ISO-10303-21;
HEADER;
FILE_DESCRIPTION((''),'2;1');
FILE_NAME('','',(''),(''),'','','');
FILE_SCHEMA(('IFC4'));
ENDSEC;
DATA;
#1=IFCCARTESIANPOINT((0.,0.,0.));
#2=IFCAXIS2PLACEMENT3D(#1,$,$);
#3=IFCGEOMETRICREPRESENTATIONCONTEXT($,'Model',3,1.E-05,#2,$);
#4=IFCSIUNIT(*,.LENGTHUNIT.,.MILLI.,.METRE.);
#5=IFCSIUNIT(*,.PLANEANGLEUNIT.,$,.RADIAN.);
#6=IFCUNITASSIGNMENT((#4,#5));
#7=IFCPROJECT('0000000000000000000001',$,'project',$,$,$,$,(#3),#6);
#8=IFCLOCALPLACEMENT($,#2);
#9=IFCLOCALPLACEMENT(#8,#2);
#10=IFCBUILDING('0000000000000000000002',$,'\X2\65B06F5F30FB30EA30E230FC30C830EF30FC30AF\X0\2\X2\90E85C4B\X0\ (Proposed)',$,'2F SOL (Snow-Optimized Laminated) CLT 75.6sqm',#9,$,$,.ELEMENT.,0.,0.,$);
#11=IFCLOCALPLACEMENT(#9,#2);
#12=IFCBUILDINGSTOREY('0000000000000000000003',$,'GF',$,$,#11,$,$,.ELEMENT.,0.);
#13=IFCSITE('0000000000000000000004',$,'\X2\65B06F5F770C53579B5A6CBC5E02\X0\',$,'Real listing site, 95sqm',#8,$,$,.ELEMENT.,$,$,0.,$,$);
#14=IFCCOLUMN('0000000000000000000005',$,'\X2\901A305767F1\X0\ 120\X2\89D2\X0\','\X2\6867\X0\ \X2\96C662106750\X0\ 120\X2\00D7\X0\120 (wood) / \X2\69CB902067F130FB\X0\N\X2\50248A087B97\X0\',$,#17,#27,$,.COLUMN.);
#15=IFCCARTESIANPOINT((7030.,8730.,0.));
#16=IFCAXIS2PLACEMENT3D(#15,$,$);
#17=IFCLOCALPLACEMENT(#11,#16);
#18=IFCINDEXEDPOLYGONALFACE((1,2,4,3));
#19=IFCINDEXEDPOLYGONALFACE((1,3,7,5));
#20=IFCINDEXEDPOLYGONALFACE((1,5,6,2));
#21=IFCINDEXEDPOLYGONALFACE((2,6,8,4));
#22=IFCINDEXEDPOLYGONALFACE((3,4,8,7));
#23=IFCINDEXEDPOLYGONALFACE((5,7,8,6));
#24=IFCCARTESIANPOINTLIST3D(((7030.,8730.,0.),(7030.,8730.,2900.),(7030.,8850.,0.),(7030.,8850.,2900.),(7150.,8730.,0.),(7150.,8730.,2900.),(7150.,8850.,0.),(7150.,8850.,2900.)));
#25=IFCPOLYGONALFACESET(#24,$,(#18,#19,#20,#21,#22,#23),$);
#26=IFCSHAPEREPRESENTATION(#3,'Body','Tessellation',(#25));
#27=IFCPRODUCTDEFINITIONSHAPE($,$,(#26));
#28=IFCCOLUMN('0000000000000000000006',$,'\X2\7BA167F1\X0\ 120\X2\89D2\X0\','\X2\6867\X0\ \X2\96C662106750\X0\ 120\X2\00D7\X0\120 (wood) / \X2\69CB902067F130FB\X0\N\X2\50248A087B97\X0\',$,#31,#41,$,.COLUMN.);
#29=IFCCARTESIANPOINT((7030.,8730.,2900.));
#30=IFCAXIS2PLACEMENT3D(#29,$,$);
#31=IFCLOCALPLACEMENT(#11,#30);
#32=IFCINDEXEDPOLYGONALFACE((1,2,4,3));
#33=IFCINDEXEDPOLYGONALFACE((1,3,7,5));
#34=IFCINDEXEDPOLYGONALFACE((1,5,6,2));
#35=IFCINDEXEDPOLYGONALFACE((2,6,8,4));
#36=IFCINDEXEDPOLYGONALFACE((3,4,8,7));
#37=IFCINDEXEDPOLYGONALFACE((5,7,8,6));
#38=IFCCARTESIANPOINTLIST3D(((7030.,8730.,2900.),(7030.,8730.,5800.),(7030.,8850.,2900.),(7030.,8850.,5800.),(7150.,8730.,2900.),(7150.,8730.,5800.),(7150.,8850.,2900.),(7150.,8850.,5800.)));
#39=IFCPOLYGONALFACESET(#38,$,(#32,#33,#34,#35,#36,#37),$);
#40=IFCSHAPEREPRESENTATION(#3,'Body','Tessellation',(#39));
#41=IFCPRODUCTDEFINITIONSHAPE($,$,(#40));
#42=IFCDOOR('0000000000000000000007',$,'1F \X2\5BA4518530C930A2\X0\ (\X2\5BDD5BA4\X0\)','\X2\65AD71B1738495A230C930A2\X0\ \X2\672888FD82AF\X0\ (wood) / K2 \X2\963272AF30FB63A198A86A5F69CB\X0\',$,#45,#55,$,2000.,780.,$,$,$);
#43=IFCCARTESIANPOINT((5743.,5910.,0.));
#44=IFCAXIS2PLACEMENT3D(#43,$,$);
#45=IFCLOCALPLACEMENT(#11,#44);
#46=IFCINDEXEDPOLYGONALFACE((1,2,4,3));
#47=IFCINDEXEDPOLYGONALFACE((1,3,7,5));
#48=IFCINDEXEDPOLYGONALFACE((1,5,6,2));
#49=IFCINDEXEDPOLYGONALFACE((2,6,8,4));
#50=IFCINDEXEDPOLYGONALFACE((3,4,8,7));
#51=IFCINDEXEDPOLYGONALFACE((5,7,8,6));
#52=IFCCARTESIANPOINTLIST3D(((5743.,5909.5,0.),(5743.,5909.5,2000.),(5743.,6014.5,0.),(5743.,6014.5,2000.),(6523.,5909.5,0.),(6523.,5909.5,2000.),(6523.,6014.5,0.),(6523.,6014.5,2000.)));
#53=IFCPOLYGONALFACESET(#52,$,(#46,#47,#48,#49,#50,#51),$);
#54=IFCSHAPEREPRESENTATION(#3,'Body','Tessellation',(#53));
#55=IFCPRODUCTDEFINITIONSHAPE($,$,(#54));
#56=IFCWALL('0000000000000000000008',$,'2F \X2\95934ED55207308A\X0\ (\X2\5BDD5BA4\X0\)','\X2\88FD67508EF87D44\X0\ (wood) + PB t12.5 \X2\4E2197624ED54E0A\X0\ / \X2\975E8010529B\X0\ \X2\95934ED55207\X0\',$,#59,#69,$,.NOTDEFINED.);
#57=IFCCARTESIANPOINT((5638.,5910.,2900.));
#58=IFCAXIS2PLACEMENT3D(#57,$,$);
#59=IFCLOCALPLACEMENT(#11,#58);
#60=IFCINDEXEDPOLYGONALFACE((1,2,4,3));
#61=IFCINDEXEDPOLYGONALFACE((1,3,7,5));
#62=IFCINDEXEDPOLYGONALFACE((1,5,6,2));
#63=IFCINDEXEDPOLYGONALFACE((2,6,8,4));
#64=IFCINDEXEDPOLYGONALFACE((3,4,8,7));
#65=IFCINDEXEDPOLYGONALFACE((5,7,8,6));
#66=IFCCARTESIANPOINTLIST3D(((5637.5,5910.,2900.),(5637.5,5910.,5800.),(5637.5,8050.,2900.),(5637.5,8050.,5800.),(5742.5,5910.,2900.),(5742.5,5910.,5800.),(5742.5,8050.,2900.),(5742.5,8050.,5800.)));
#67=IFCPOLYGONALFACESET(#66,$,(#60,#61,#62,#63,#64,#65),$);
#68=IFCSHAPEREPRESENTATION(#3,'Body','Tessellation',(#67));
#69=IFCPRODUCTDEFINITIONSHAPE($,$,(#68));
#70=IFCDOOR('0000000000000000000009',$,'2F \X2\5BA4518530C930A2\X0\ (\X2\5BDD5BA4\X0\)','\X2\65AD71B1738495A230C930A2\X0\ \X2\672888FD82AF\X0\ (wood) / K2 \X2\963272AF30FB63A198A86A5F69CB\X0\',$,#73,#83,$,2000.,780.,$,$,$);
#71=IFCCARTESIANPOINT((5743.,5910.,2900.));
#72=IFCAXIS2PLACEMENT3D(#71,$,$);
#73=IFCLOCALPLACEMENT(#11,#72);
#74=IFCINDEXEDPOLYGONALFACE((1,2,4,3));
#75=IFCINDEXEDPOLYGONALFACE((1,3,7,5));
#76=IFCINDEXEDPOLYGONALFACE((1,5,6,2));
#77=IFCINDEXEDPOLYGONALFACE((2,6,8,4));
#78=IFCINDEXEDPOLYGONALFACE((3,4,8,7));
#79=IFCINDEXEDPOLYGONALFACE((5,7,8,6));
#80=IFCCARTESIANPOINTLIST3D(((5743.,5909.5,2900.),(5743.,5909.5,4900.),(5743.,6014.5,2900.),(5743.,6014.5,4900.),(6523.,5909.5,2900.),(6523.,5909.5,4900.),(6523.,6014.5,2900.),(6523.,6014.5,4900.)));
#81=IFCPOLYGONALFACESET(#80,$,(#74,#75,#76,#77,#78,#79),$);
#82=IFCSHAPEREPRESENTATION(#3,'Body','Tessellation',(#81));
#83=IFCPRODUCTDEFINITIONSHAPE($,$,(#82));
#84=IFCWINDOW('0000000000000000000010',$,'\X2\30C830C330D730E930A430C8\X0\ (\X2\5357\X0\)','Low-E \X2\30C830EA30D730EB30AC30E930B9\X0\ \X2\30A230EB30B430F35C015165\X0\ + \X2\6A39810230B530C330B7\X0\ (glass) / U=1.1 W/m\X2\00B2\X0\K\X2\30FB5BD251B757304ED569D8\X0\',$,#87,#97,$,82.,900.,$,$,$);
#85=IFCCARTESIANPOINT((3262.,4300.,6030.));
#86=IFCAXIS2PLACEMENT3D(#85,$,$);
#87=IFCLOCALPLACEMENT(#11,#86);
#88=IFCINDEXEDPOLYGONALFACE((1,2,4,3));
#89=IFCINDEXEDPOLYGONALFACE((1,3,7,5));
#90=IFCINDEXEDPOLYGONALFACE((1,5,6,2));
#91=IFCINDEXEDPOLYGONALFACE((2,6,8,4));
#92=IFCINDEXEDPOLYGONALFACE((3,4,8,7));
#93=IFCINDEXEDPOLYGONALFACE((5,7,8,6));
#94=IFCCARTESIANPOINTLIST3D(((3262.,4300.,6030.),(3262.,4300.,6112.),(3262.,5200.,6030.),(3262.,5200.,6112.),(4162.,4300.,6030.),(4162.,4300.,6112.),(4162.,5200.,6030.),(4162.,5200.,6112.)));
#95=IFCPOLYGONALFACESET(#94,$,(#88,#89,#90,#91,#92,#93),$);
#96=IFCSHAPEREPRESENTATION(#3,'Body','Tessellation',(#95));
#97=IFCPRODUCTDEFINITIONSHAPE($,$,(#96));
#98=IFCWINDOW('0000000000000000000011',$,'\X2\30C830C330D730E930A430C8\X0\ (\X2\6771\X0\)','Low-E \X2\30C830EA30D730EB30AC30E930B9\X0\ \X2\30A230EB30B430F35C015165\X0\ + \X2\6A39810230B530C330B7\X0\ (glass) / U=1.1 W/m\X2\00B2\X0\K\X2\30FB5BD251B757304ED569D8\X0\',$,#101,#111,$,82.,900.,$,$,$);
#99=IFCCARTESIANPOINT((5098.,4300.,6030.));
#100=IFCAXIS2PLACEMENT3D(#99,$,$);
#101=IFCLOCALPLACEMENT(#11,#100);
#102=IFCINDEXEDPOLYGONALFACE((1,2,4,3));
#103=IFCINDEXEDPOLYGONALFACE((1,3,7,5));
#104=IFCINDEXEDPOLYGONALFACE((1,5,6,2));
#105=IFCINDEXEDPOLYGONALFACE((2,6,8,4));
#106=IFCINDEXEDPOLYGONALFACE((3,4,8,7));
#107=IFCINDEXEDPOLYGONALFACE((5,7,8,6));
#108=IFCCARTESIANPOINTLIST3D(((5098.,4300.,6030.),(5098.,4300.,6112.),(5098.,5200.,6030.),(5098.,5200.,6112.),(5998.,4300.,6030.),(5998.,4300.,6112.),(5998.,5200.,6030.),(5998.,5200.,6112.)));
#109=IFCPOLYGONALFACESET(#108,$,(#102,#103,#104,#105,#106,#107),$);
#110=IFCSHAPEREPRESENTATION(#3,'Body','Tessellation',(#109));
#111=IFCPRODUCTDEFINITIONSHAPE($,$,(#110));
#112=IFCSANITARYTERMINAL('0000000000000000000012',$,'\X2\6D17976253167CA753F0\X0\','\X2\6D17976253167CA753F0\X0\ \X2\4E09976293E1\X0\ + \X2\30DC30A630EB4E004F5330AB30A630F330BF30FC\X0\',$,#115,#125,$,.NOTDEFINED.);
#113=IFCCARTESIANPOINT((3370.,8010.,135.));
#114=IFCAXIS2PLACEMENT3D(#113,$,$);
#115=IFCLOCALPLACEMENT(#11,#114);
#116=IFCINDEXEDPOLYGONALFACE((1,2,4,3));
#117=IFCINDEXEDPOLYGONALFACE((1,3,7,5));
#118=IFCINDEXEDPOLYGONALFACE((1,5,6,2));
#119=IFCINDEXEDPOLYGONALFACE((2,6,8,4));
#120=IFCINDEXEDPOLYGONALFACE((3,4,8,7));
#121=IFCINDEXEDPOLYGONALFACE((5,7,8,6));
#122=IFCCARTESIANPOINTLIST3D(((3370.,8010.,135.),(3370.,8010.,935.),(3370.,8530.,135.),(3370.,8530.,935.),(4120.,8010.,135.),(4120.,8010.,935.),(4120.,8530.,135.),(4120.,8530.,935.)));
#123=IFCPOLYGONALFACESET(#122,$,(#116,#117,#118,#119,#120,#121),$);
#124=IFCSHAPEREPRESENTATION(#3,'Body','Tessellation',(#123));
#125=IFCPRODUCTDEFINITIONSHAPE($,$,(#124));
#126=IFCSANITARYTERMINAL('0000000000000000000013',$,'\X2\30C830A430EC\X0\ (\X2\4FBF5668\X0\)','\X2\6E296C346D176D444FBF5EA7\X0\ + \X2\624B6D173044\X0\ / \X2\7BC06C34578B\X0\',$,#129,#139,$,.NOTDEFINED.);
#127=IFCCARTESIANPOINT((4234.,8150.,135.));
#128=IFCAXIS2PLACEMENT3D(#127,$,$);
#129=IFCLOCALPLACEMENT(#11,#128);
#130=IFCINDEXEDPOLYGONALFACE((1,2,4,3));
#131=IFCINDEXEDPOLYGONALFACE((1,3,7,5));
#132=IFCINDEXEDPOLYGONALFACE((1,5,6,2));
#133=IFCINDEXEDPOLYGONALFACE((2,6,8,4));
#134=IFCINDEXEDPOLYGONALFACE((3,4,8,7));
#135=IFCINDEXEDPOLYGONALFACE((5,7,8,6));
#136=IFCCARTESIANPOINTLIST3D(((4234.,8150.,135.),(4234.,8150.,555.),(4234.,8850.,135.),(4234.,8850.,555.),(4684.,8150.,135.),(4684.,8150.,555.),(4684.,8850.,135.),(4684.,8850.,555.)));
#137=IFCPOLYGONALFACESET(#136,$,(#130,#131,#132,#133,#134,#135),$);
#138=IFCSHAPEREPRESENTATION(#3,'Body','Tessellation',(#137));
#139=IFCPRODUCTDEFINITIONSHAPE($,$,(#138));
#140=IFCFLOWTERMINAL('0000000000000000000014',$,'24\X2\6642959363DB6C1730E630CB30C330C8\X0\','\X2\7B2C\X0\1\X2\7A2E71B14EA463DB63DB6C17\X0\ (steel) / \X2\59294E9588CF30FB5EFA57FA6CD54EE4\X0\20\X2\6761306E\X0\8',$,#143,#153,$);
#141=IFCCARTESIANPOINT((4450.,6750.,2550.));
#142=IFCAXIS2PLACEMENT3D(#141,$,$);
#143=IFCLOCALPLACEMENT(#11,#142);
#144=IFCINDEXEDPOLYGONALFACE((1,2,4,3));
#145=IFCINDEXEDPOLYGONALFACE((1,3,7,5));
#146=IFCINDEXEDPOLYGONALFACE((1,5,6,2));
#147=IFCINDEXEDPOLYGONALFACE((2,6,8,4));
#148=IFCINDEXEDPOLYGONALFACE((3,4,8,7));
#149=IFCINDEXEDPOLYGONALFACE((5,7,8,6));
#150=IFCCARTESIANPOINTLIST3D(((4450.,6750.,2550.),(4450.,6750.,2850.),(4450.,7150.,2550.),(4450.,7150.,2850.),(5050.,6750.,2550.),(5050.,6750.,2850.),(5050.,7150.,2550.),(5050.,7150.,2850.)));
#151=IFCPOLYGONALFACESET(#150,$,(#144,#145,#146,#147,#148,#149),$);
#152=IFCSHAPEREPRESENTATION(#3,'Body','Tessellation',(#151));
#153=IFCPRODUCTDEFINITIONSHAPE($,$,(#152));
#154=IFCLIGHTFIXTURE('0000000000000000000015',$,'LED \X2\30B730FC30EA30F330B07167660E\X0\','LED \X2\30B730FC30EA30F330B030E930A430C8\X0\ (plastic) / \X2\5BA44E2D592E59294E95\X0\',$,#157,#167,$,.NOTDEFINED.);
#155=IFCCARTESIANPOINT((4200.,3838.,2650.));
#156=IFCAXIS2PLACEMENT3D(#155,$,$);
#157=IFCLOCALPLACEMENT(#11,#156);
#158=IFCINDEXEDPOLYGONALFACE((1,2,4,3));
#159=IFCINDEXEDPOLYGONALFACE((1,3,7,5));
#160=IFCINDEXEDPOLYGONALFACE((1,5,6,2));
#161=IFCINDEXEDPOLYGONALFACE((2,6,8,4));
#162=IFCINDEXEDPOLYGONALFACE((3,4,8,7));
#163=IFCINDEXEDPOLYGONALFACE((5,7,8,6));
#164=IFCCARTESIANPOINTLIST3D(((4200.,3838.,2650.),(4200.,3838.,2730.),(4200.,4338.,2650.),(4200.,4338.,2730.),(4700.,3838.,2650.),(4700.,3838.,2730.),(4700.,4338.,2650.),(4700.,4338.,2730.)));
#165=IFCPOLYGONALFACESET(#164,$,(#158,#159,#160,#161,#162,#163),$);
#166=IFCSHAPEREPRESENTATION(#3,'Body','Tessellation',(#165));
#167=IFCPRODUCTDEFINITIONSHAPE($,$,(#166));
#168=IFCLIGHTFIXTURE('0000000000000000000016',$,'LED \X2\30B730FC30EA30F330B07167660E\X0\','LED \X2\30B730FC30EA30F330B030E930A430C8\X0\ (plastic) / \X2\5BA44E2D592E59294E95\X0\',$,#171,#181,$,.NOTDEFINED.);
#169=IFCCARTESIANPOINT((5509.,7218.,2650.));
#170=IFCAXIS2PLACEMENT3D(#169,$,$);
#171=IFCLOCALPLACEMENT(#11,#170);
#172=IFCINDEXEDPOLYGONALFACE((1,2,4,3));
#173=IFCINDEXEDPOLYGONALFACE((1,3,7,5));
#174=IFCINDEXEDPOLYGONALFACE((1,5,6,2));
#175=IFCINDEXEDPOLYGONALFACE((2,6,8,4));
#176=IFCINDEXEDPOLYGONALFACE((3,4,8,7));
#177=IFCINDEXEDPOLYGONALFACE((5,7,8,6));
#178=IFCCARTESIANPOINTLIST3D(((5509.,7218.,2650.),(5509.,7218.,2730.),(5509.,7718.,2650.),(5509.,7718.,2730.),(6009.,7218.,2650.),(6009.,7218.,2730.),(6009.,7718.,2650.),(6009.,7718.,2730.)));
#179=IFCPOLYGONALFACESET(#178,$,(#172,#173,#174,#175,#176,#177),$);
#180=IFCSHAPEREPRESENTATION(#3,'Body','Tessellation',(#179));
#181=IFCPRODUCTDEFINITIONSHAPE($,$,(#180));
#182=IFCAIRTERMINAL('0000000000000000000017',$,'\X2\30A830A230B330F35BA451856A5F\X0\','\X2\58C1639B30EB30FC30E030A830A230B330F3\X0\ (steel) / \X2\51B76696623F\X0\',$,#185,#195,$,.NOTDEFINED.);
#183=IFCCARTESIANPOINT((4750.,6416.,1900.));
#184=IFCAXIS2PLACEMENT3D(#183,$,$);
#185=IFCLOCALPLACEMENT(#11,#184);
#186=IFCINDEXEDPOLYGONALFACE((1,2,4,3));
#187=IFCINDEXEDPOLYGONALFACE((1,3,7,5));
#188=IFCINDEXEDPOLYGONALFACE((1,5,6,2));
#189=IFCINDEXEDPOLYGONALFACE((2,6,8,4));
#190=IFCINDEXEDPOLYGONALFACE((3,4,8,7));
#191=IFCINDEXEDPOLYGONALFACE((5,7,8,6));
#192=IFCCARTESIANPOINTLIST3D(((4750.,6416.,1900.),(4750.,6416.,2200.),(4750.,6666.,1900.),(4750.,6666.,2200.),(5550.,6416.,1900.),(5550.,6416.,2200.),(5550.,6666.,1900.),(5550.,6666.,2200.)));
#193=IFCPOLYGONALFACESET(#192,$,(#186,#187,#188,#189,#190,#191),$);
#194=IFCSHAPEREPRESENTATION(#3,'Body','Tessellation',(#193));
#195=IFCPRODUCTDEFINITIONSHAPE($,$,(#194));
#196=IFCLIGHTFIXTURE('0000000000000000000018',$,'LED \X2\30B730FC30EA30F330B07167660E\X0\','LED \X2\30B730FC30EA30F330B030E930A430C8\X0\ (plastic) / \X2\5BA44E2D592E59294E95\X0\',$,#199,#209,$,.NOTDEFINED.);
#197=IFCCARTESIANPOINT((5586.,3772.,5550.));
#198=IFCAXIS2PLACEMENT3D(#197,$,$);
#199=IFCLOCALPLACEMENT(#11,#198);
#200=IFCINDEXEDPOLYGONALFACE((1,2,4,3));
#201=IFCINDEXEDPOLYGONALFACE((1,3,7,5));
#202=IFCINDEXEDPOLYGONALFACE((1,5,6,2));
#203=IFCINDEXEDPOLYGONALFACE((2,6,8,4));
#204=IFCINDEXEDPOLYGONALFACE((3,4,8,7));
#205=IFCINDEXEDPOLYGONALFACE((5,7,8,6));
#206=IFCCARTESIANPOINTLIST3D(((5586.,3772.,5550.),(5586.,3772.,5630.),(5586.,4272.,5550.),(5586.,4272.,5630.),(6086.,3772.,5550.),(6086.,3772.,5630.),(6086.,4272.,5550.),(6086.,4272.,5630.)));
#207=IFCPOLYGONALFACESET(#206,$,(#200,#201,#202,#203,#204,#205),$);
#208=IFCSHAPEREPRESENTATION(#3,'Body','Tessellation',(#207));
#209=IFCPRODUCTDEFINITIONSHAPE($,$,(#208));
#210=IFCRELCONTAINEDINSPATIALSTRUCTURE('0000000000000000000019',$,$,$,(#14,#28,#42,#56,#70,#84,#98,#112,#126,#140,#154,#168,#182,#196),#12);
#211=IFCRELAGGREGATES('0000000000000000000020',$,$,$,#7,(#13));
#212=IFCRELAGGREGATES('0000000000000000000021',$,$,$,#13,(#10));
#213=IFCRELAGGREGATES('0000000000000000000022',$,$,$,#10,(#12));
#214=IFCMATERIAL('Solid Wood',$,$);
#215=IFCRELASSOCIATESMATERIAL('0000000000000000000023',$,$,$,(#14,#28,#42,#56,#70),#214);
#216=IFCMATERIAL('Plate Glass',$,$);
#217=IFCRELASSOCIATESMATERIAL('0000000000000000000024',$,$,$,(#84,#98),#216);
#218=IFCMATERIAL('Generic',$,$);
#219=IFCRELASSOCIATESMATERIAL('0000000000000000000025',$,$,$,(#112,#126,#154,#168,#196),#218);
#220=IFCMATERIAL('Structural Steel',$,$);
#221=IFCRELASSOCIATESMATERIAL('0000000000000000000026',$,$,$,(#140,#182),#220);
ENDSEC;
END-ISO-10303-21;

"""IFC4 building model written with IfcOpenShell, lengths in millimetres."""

from ifc_helpers import new_model, si_unit, frame, frame_2d, origin, place, context, project, spatial, rectangle, extrude, material, element, save


model = new_model("IFC4")

# Units and contexts
model_context = context("Model", 3, precision=1e-05, world=origin())
ifc_project = project(units=[si_unit("LENGTHUNIT", "METRE", prefix="MILLI"), si_unit("PLANEANGLEUNIT", "RADIAN")], contexts=[model_context])

# Site, building, storey
site_placement = place(None, origin())
site = spatial("IfcSite", under=ifc_project, at=site_placement, Name="新潟県南魚沼市", ObjectType="Real listing site, 95sqm", CompositionType="ELEMENT", RefElevation=0.0)
building_placement = place(site_placement, origin())
building = spatial("IfcBuilding", under=site, at=building_placement, Name="新潟・リモートワーク2部屋 (Proposed)", ObjectType="2F SOL (Snow-Optimized Laminated) CLT 75.6sqm", CompositionType="ELEMENT", ElevationOfRefHeight=0.0, ElevationOfTerrain=0.0)
storey_placement = place(building_placement, origin())
storey = spatial("IfcBuildingStorey", under=building, at=storey_placement, Name="GF", CompositionType="ELEMENT", Elevation=0.0)

# Columns
ifc_material_1 = material(Name="Solid Wood")
column_1_placement = place(storey_placement, frame((7030.0, 8730.0, 0.0)))
element("IfcColumn", 1, at=column_1_placement, inside=storey, material=ifc_material_1, Name="通し柱 120角", Description="桧 集成材 120×120 (wood) / 構造柱・N値計算", PredefinedType="COLUMN", context=model_context, shape_type="SweptSolid", body=[
    extrude(rectangle(XDim=120.0, YDim=120.0, at=frame_2d((60.0, 60.0))), frame((7030.0, 8730.0, 0.0)), (0.0, 0.0, 1.0), 2900.0),
])
column_2_placement = place(storey_placement, frame((7030.0, 8730.0, 2900.0)))
element("IfcColumn", 2, at=column_2_placement, inside=storey, material=ifc_material_1, Name="管柱 120角", Description="桧 集成材 120×120 (wood) / 構造柱・N値計算", PredefinedType="COLUMN", context=model_context, shape_type="SweptSolid", body=[
    extrude(rectangle(XDim=120.0, YDim=120.0, at=frame_2d((60.0, 60.0))), frame((7030.0, 8730.0, 2900.0)), (0.0, 0.0, 1.0), 2900.0),
])

# Door
door_1_placement = place(storey_placement, frame((5743.0, 5910.0, 0.0)))
element("IfcDoor", 3, at=door_1_placement, inside=storey, material=ifc_material_1, Name="1F 室内ドア (寝室)", Description="断熱玄関ドア 木製芯 (wood) / K2 防犯・採風機構", OverallHeight=2000.0, OverallWidth=780.0, context=model_context, shape_type="SweptSolid", body=[
    extrude(rectangle(XDim=780.0, YDim=105.0, at=frame_2d((390.0, 52.0))), frame((5743.0, 5910.0, 0.0)), (0.0, 0.0, 1.0), 2000.0),
])

# Wall
wall_1_placement = place(storey_placement, frame((5638.0, 5910.0, 2900.0)))
element("IfcWall", 4, at=wall_1_placement, inside=storey, material=ifc_material_1, Name="2F 間仕切り (寝室)", Description="製材軸組 (wood) + PB t12.5 両面仕上 / 非耐力 間仕切", PredefinedType="NOTDEFINED", context=model_context, shape_type="SweptSolid", body=[
    extrude(rectangle(XDim=105.0, YDim=2140.0, at=frame_2d((52.0, 1070.0))), frame((5638.0, 5910.0, 2900.0)), (0.0, 0.0, 1.0), 2900.0),
])

# Door
door_2_placement = place(storey_placement, frame((5743.0, 5910.0, 2900.0)))
element("IfcDoor", 5, at=door_2_placement, inside=storey, material=ifc_material_1, Name="2F 室内ドア (寝室)", Description="断熱玄関ドア 木製芯 (wood) / K2 防犯・採風機構", OverallHeight=2000.0, OverallWidth=780.0, context=model_context, shape_type="SweptSolid", body=[
    extrude(rectangle(XDim=780.0, YDim=105.0, at=frame_2d((390.0, 52.0))), frame((5743.0, 5910.0, 2900.0)), (0.0, 0.0, 1.0), 2000.0),
])

# Windows
ifc_material_2 = material(Name="Plate Glass")
window_1_placement = place(storey_placement, frame((3262.0, 4300.0, 6030.0)))
element("IfcWindow", 6, at=window_1_placement, inside=storey, material=ifc_material_2, Name="トップライト (南)", Description="Low-E トリプルガラス アルゴン封入 + 樹脂サッシ (glass) / U=1.1 W/m²K・寒冷地仕様", OverallHeight=82.0, OverallWidth=900.0, context=model_context, shape_type="SweptSolid", body=[
    extrude(rectangle(XDim=900.0, YDim=900.0, at=frame_2d((450.0, 450.0))), frame((3262.0, 4300.0, 6030.0)), (0.0, 0.0, 1.0), 82.0),
])
window_2_placement = place(storey_placement, frame((5098.0, 4300.0, 6030.0)))
element("IfcWindow", 7, at=window_2_placement, inside=storey, material=ifc_material_2, Name="トップライト (東)", Description="Low-E トリプルガラス アルゴン封入 + 樹脂サッシ (glass) / U=1.1 W/m²K・寒冷地仕様", OverallHeight=82.0, OverallWidth=900.0, context=model_context, shape_type="SweptSolid", body=[
    extrude(rectangle(XDim=900.0, YDim=900.0, at=frame_2d((450.0, 450.0))), frame((5098.0, 4300.0, 6030.0)), (0.0, 0.0, 1.0), 82.0),
])

# Sanitary terminals
ifc_material_3 = material(Name="Generic")
sanitary_terminal_1_placement = place(storey_placement, frame((3370.0, 8010.0, 135.0)))
element("IfcSanitaryTerminal", 8, at=sanitary_terminal_1_placement, inside=storey, material=ifc_material_3, Name="洗面化粧台", Description="洗面化粧台 三面鏡 + ボウル一体カウンター", PredefinedType="NOTDEFINED", context=model_context, shape_type="SweptSolid", body=[
    extrude(rectangle(XDim=750.0, YDim=520.0, at=frame_2d((375.0, 260.0))), frame((3370.0, 8010.0, 135.0)), (0.0, 0.0, 1.0), 800.0),
])
sanitary_terminal_2_placement = place(storey_placement, frame((4234.0, 8150.0, 135.0)))
element("IfcSanitaryTerminal", 9, at=sanitary_terminal_2_placement, inside=storey, material=ifc_material_3, Name="トイレ (便器)", Description="温水洗浄便座 + 手洗い / 節水型", PredefinedType="NOTDEFINED", context=model_context, shape_type="SweptSolid", body=[
    extrude(rectangle(XDim=450.0, YDim=700.0, at=frame_2d((225.0, 350.0))), frame((4234.0, 8150.0, 135.0)), (0.0, 0.0, 1.0), 420.0),
])

# Flow terminal
ifc_material_4 = material(Name="Structural Steel")
flow_terminal_placement = place(storey_placement, frame((4450.0, 6750.0, 2550.0)))
element("IfcFlowTerminal", 10, at=flow_terminal_placement, inside=storey, material=ifc_material_4, Name="24時間換気ユニット", Description="第1種熱交換換気 (steel) / 天井裏・建基法令20条の8", context=model_context, shape_type="SweptSolid", body=[
    extrude(rectangle(XDim=600.0, YDim=400.0, at=frame_2d((300.0, 200.0))), frame((4450.0, 6750.0, 2550.0)), (0.0, 0.0, 1.0), 300.0),
])

# Light fixtures
light_fixture_1_placement = place(storey_placement, frame((4200.0, 3838.0, 2650.0)))
element("IfcLightFixture", 11, at=light_fixture_1_placement, inside=storey, material=ifc_material_3, Name="LED シーリング照明", Description="LED シーリングライト (plastic) / 室中央天井", PredefinedType="NOTDEFINED", context=model_context, shape_type="SweptSolid", body=[
    extrude(rectangle(XDim=500.0, YDim=500.0, at=frame_2d((250.0, 250.0))), frame((4200.0, 3838.0, 2650.0)), (0.0, 0.0, 1.0), 80.0),
])
light_fixture_2_placement = place(storey_placement, frame((5509.0, 7218.0, 2650.0)))
element("IfcLightFixture", 12, at=light_fixture_2_placement, inside=storey, material=ifc_material_3, Name="LED シーリング照明", Description="LED シーリングライト (plastic) / 室中央天井", PredefinedType="NOTDEFINED", context=model_context, shape_type="SweptSolid", body=[
    extrude(rectangle(XDim=500.0, YDim=500.0, at=frame_2d((250.0, 250.0))), frame((5509.0, 7218.0, 2650.0)), (0.0, 0.0, 1.0), 80.0),
])

# Air terminal
air_terminal_placement = place(storey_placement, frame((4750.0, 6416.0, 1900.0)))
element("IfcAirTerminal", 13, at=air_terminal_placement, inside=storey, material=ifc_material_4, Name="エアコン室内機", Description="壁掛ルームエアコン (steel) / 冷暖房", PredefinedType="NOTDEFINED", context=model_context, shape_type="SweptSolid", body=[
    extrude(rectangle(XDim=800.0, YDim=250.0, at=frame_2d((400.0, 125.0))), frame((4750.0, 6416.0, 1900.0)), (0.0, 0.0, 1.0), 300.0),
])

# Light fixture
light_fixture_3_placement = place(storey_placement, frame((5586.0, 3772.0, 5550.0)))
element("IfcLightFixture", 14, at=light_fixture_3_placement, inside=storey, material=ifc_material_3, Name="LED シーリング照明", Description="LED シーリングライト (plastic) / 室中央天井", PredefinedType="NOTDEFINED", context=model_context, shape_type="SweptSolid", body=[
    extrude(rectangle(XDim=500.0, YDim=500.0, at=frame_2d((250.0, 250.0))), frame((5586.0, 3772.0, 5550.0)), (0.0, 0.0, 1.0), 80.0),
])

save(model, "model.ifc")
